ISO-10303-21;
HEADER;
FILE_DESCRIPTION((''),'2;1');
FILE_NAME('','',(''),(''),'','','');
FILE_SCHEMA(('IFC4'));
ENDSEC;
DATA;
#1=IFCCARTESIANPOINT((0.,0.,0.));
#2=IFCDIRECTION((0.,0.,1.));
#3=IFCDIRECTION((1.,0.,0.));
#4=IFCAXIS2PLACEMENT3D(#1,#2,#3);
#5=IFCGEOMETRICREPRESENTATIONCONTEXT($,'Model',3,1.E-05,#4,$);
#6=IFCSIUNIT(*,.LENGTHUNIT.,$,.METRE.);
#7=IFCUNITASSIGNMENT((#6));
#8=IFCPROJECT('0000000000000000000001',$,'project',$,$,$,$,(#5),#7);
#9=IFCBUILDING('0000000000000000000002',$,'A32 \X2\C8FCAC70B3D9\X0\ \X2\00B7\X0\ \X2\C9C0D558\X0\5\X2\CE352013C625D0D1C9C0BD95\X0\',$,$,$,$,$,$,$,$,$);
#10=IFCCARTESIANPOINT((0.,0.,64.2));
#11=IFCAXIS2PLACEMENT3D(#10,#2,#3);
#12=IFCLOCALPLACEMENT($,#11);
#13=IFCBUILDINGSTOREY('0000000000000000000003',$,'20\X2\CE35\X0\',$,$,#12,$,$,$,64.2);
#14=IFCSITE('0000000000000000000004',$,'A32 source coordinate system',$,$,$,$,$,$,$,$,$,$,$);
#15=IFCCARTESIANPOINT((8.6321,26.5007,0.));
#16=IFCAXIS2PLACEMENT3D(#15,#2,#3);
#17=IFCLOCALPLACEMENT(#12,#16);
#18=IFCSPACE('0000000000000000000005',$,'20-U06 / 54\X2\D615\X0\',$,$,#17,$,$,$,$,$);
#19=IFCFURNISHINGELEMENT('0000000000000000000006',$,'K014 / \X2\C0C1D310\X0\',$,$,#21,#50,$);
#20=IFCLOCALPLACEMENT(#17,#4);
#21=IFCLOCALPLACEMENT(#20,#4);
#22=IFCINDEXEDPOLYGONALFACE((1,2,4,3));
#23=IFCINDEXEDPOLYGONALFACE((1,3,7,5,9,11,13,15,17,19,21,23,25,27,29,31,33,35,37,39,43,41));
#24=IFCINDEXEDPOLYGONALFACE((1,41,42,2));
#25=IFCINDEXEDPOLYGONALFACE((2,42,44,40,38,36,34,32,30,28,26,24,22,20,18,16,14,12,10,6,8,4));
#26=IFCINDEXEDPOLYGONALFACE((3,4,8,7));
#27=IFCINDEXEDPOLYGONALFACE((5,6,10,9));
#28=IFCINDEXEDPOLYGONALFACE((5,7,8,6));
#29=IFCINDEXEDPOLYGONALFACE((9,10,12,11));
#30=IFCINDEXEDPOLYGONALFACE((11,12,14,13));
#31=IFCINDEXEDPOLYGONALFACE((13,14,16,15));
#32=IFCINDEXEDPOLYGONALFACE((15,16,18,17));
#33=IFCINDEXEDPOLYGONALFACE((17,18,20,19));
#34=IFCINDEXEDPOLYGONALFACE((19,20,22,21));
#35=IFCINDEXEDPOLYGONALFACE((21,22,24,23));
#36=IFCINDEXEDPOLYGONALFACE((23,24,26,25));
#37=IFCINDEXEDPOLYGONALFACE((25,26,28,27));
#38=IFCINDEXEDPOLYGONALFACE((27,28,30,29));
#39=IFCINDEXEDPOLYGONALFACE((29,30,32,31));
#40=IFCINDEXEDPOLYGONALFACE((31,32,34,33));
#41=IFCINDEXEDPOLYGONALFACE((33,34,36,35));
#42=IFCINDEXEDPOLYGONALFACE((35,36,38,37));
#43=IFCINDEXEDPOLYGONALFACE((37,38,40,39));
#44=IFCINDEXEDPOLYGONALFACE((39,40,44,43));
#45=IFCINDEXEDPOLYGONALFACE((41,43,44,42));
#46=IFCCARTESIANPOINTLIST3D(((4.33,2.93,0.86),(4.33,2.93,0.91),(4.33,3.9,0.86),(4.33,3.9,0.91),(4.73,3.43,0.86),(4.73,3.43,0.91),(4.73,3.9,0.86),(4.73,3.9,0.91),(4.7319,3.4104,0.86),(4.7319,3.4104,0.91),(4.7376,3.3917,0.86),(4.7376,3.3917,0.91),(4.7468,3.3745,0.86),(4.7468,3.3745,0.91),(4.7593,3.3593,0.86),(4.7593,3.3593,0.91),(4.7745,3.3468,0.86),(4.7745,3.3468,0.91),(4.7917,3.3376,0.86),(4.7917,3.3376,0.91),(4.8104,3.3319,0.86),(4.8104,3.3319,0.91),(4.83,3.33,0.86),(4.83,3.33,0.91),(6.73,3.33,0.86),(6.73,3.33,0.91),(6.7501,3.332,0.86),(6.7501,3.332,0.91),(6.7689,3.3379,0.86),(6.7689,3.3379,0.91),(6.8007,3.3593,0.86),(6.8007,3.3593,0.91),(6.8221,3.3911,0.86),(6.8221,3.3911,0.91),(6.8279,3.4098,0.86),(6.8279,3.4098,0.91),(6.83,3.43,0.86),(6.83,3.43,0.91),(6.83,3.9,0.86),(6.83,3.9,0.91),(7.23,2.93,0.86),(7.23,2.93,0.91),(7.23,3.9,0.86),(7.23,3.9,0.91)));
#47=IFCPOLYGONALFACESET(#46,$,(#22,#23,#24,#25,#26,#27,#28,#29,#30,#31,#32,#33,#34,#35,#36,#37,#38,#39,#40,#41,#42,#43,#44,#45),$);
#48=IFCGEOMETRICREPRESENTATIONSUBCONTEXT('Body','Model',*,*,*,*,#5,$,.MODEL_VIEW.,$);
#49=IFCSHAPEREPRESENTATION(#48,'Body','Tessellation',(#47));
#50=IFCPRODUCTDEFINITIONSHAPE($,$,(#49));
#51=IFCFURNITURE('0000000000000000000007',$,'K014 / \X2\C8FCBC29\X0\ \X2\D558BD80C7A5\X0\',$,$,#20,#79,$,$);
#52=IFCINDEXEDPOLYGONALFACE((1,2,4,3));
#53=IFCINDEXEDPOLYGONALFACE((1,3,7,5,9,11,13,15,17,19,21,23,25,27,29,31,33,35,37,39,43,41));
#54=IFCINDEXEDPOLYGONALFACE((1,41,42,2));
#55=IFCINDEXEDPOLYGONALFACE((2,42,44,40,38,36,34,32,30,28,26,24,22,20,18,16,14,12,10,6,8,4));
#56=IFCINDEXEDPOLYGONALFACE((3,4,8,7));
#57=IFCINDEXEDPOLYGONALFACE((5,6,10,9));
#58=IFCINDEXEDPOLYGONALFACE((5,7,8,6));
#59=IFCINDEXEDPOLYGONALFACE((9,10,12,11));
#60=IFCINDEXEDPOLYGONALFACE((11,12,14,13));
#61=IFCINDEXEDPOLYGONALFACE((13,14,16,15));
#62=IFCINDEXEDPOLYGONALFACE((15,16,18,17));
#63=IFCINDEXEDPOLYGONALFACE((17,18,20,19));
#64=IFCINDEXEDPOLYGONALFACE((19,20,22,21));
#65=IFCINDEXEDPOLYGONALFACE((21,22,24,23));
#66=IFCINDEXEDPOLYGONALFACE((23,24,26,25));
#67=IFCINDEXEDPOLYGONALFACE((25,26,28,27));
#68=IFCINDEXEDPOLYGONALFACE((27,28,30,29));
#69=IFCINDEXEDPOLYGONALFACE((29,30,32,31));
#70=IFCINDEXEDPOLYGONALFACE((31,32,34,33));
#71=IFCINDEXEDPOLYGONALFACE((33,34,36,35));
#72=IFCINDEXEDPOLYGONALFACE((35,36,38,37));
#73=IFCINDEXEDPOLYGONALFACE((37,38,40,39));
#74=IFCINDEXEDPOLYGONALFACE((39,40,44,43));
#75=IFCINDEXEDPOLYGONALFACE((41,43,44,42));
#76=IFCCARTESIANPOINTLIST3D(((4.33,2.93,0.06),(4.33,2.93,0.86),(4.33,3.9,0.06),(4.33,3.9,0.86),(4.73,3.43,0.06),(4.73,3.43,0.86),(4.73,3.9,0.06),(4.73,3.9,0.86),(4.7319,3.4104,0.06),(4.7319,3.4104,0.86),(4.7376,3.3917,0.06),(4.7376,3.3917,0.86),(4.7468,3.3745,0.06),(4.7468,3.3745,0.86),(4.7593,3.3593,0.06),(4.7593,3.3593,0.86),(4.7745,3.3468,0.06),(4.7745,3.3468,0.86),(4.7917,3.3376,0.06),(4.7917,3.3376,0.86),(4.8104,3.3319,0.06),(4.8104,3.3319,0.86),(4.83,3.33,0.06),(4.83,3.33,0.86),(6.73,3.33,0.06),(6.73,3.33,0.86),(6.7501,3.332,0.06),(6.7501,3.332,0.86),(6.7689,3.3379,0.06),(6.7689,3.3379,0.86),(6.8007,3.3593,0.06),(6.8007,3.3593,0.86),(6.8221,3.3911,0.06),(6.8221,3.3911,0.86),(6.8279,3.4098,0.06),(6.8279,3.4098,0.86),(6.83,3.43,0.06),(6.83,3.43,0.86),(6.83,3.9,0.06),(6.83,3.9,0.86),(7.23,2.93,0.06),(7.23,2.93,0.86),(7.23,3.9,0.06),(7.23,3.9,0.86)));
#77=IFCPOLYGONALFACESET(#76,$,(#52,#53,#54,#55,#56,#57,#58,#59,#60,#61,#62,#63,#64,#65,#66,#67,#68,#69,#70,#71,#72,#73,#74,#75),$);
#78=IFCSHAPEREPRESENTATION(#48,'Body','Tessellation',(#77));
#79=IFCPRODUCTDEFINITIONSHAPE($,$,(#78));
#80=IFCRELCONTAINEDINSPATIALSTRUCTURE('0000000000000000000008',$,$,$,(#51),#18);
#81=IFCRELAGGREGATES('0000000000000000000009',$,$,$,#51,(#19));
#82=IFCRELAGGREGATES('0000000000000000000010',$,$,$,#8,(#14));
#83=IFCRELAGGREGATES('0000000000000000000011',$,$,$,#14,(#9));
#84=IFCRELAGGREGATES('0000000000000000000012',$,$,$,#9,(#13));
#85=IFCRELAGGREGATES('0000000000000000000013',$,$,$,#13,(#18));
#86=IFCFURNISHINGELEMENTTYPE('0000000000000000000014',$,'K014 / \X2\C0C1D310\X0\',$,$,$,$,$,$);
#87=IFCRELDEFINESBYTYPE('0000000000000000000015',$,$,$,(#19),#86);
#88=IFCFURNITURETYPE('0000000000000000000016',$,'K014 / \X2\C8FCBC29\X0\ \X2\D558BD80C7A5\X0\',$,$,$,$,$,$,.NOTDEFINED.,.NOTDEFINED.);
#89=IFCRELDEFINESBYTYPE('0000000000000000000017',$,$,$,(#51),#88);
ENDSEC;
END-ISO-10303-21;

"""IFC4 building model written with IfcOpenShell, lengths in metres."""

from ifc_helpers import new_model, si_unit, frame, origin, origin_with_axes, place, context, subcontext, project, spatial, polyline, outline, extrude, source, transform, mapped, type_object, type_shapes, element, aggregate, save


model = new_model("IFC4")

# Units and contexts
model_context = context("Model", 3, precision=1e-05, world=origin_with_axes())
body_context = subcontext(model_context, "Body", "Model", "MODEL_VIEW")
ifc_project = project(units=[si_unit("LENGTHUNIT", "METRE")], contexts=[model_context])

# Site, building, storey, space
site = spatial("IfcSite", under=ifc_project, Name="A32 source coordinate system")
building = spatial("IfcBuilding", under=site, Name="A32 주거동 · 지하5층–옥탑지붕")
storey_placement = place(None, frame((0.0, 0.0, 64.2), z_axis=(0.0, 0.0, 1.0), x_axis=(1.0, 0.0, 0.0)))
storey = spatial("IfcBuildingStorey", under=building, at=storey_placement, Name="20층", Elevation=64.2)
space_placement = place(storey_placement, frame((8.6321, 26.5007, 0.0), z_axis=(0.0, 0.0, 1.0), x_axis=(1.0, 0.0, 0.0)))
space = spatial("IfcSpace", under=storey, at=space_placement, Name="20-U06 / 54형")

# Furnishing element
furnishing_element_type_1 = type_object("IfcFurnishingElementType", Name="K014 / 상판")
shared_shape_1 = source(origin(), body_context, "Body", "SweptSolid", [
    extrude(outline(polyline([(4.33, 2.93), (4.33, 3.9), (4.73, 3.9), (4.73, 3.43), (4.7319, 3.4104), (4.7376, 3.3917), (4.7468, 3.3745), (4.7593, 3.3593), (4.7745, 3.3468), (4.7917, 3.3376), (4.8104, 3.3319), (4.83, 3.33), (6.73, 3.33), (6.7501, 3.332), (6.7689, 3.3379), (6.8007, 3.3593), (6.8221, 3.3911), (6.8279, 3.4098), (6.83, 3.43), (6.83, 3.9), (7.23, 3.9), (7.23, 2.93), (4.33, 2.93)])), frame((0.0, 0.0, 0.86)), (0.0, 0.0, 1.0), 0.05),
])
type_shapes(furnishing_element_type_1, [shared_shape_1])
furniture_1_placement = place(space_placement, origin_with_axes())
furnishing_1_placement = place(furniture_1_placement, origin_with_axes())
furnishing_1 = element("IfcFurnishingElement", 1, at=furnishing_1_placement, type_object=furnishing_element_type_1, Name="K014 / 상판", context=body_context, shape_type="MappedRepresentation", body=[
    mapped(shared_shape_1, transform((0.0, 0.0, 0.0), scale=1.0)),
])

# Furniture
furniture_type_1 = type_object("IfcFurnitureType", Name="K014 / 주방 하부장", AssemblyPlace="NOTDEFINED", PredefinedType="NOTDEFINED")
shared_shape_2 = source(origin(), body_context, "Body", "SweptSolid", [
    extrude(outline(polyline([(7.23, 2.93), (4.33, 2.93), (4.33, 3.9), (4.73, 3.9), (4.73, 3.43), (4.7319, 3.4104), (4.7376, 3.3917), (4.7468, 3.3745), (4.7593, 3.3593), (4.7745, 3.3468), (4.7917, 3.3376), (4.8104, 3.3319), (4.83, 3.33), (6.73, 3.33), (6.7501, 3.332), (6.7689, 3.3379), (6.8007, 3.3593), (6.8221, 3.3911), (6.8279, 3.4098), (6.83, 3.43), (6.83, 3.9), (7.23, 3.9), (7.23, 2.93)])), frame((0.0, 0.0, 0.06)), (0.0, 0.0, 1.0), 0.8),
])
type_shapes(furniture_type_1, [shared_shape_2])
furniture_1 = element("IfcFurniture", 2, at=furniture_1_placement, inside=space, type_object=furniture_type_1, Name="K014 / 주방 하부장", context=body_context, shape_type="MappedRepresentation", body=[
    mapped(shared_shape_2, transform((0.0, 0.0, 0.0), scale=1.0)),
])
aggregate(furniture_1, [furnishing_1])

save(model, "model.ifc")
